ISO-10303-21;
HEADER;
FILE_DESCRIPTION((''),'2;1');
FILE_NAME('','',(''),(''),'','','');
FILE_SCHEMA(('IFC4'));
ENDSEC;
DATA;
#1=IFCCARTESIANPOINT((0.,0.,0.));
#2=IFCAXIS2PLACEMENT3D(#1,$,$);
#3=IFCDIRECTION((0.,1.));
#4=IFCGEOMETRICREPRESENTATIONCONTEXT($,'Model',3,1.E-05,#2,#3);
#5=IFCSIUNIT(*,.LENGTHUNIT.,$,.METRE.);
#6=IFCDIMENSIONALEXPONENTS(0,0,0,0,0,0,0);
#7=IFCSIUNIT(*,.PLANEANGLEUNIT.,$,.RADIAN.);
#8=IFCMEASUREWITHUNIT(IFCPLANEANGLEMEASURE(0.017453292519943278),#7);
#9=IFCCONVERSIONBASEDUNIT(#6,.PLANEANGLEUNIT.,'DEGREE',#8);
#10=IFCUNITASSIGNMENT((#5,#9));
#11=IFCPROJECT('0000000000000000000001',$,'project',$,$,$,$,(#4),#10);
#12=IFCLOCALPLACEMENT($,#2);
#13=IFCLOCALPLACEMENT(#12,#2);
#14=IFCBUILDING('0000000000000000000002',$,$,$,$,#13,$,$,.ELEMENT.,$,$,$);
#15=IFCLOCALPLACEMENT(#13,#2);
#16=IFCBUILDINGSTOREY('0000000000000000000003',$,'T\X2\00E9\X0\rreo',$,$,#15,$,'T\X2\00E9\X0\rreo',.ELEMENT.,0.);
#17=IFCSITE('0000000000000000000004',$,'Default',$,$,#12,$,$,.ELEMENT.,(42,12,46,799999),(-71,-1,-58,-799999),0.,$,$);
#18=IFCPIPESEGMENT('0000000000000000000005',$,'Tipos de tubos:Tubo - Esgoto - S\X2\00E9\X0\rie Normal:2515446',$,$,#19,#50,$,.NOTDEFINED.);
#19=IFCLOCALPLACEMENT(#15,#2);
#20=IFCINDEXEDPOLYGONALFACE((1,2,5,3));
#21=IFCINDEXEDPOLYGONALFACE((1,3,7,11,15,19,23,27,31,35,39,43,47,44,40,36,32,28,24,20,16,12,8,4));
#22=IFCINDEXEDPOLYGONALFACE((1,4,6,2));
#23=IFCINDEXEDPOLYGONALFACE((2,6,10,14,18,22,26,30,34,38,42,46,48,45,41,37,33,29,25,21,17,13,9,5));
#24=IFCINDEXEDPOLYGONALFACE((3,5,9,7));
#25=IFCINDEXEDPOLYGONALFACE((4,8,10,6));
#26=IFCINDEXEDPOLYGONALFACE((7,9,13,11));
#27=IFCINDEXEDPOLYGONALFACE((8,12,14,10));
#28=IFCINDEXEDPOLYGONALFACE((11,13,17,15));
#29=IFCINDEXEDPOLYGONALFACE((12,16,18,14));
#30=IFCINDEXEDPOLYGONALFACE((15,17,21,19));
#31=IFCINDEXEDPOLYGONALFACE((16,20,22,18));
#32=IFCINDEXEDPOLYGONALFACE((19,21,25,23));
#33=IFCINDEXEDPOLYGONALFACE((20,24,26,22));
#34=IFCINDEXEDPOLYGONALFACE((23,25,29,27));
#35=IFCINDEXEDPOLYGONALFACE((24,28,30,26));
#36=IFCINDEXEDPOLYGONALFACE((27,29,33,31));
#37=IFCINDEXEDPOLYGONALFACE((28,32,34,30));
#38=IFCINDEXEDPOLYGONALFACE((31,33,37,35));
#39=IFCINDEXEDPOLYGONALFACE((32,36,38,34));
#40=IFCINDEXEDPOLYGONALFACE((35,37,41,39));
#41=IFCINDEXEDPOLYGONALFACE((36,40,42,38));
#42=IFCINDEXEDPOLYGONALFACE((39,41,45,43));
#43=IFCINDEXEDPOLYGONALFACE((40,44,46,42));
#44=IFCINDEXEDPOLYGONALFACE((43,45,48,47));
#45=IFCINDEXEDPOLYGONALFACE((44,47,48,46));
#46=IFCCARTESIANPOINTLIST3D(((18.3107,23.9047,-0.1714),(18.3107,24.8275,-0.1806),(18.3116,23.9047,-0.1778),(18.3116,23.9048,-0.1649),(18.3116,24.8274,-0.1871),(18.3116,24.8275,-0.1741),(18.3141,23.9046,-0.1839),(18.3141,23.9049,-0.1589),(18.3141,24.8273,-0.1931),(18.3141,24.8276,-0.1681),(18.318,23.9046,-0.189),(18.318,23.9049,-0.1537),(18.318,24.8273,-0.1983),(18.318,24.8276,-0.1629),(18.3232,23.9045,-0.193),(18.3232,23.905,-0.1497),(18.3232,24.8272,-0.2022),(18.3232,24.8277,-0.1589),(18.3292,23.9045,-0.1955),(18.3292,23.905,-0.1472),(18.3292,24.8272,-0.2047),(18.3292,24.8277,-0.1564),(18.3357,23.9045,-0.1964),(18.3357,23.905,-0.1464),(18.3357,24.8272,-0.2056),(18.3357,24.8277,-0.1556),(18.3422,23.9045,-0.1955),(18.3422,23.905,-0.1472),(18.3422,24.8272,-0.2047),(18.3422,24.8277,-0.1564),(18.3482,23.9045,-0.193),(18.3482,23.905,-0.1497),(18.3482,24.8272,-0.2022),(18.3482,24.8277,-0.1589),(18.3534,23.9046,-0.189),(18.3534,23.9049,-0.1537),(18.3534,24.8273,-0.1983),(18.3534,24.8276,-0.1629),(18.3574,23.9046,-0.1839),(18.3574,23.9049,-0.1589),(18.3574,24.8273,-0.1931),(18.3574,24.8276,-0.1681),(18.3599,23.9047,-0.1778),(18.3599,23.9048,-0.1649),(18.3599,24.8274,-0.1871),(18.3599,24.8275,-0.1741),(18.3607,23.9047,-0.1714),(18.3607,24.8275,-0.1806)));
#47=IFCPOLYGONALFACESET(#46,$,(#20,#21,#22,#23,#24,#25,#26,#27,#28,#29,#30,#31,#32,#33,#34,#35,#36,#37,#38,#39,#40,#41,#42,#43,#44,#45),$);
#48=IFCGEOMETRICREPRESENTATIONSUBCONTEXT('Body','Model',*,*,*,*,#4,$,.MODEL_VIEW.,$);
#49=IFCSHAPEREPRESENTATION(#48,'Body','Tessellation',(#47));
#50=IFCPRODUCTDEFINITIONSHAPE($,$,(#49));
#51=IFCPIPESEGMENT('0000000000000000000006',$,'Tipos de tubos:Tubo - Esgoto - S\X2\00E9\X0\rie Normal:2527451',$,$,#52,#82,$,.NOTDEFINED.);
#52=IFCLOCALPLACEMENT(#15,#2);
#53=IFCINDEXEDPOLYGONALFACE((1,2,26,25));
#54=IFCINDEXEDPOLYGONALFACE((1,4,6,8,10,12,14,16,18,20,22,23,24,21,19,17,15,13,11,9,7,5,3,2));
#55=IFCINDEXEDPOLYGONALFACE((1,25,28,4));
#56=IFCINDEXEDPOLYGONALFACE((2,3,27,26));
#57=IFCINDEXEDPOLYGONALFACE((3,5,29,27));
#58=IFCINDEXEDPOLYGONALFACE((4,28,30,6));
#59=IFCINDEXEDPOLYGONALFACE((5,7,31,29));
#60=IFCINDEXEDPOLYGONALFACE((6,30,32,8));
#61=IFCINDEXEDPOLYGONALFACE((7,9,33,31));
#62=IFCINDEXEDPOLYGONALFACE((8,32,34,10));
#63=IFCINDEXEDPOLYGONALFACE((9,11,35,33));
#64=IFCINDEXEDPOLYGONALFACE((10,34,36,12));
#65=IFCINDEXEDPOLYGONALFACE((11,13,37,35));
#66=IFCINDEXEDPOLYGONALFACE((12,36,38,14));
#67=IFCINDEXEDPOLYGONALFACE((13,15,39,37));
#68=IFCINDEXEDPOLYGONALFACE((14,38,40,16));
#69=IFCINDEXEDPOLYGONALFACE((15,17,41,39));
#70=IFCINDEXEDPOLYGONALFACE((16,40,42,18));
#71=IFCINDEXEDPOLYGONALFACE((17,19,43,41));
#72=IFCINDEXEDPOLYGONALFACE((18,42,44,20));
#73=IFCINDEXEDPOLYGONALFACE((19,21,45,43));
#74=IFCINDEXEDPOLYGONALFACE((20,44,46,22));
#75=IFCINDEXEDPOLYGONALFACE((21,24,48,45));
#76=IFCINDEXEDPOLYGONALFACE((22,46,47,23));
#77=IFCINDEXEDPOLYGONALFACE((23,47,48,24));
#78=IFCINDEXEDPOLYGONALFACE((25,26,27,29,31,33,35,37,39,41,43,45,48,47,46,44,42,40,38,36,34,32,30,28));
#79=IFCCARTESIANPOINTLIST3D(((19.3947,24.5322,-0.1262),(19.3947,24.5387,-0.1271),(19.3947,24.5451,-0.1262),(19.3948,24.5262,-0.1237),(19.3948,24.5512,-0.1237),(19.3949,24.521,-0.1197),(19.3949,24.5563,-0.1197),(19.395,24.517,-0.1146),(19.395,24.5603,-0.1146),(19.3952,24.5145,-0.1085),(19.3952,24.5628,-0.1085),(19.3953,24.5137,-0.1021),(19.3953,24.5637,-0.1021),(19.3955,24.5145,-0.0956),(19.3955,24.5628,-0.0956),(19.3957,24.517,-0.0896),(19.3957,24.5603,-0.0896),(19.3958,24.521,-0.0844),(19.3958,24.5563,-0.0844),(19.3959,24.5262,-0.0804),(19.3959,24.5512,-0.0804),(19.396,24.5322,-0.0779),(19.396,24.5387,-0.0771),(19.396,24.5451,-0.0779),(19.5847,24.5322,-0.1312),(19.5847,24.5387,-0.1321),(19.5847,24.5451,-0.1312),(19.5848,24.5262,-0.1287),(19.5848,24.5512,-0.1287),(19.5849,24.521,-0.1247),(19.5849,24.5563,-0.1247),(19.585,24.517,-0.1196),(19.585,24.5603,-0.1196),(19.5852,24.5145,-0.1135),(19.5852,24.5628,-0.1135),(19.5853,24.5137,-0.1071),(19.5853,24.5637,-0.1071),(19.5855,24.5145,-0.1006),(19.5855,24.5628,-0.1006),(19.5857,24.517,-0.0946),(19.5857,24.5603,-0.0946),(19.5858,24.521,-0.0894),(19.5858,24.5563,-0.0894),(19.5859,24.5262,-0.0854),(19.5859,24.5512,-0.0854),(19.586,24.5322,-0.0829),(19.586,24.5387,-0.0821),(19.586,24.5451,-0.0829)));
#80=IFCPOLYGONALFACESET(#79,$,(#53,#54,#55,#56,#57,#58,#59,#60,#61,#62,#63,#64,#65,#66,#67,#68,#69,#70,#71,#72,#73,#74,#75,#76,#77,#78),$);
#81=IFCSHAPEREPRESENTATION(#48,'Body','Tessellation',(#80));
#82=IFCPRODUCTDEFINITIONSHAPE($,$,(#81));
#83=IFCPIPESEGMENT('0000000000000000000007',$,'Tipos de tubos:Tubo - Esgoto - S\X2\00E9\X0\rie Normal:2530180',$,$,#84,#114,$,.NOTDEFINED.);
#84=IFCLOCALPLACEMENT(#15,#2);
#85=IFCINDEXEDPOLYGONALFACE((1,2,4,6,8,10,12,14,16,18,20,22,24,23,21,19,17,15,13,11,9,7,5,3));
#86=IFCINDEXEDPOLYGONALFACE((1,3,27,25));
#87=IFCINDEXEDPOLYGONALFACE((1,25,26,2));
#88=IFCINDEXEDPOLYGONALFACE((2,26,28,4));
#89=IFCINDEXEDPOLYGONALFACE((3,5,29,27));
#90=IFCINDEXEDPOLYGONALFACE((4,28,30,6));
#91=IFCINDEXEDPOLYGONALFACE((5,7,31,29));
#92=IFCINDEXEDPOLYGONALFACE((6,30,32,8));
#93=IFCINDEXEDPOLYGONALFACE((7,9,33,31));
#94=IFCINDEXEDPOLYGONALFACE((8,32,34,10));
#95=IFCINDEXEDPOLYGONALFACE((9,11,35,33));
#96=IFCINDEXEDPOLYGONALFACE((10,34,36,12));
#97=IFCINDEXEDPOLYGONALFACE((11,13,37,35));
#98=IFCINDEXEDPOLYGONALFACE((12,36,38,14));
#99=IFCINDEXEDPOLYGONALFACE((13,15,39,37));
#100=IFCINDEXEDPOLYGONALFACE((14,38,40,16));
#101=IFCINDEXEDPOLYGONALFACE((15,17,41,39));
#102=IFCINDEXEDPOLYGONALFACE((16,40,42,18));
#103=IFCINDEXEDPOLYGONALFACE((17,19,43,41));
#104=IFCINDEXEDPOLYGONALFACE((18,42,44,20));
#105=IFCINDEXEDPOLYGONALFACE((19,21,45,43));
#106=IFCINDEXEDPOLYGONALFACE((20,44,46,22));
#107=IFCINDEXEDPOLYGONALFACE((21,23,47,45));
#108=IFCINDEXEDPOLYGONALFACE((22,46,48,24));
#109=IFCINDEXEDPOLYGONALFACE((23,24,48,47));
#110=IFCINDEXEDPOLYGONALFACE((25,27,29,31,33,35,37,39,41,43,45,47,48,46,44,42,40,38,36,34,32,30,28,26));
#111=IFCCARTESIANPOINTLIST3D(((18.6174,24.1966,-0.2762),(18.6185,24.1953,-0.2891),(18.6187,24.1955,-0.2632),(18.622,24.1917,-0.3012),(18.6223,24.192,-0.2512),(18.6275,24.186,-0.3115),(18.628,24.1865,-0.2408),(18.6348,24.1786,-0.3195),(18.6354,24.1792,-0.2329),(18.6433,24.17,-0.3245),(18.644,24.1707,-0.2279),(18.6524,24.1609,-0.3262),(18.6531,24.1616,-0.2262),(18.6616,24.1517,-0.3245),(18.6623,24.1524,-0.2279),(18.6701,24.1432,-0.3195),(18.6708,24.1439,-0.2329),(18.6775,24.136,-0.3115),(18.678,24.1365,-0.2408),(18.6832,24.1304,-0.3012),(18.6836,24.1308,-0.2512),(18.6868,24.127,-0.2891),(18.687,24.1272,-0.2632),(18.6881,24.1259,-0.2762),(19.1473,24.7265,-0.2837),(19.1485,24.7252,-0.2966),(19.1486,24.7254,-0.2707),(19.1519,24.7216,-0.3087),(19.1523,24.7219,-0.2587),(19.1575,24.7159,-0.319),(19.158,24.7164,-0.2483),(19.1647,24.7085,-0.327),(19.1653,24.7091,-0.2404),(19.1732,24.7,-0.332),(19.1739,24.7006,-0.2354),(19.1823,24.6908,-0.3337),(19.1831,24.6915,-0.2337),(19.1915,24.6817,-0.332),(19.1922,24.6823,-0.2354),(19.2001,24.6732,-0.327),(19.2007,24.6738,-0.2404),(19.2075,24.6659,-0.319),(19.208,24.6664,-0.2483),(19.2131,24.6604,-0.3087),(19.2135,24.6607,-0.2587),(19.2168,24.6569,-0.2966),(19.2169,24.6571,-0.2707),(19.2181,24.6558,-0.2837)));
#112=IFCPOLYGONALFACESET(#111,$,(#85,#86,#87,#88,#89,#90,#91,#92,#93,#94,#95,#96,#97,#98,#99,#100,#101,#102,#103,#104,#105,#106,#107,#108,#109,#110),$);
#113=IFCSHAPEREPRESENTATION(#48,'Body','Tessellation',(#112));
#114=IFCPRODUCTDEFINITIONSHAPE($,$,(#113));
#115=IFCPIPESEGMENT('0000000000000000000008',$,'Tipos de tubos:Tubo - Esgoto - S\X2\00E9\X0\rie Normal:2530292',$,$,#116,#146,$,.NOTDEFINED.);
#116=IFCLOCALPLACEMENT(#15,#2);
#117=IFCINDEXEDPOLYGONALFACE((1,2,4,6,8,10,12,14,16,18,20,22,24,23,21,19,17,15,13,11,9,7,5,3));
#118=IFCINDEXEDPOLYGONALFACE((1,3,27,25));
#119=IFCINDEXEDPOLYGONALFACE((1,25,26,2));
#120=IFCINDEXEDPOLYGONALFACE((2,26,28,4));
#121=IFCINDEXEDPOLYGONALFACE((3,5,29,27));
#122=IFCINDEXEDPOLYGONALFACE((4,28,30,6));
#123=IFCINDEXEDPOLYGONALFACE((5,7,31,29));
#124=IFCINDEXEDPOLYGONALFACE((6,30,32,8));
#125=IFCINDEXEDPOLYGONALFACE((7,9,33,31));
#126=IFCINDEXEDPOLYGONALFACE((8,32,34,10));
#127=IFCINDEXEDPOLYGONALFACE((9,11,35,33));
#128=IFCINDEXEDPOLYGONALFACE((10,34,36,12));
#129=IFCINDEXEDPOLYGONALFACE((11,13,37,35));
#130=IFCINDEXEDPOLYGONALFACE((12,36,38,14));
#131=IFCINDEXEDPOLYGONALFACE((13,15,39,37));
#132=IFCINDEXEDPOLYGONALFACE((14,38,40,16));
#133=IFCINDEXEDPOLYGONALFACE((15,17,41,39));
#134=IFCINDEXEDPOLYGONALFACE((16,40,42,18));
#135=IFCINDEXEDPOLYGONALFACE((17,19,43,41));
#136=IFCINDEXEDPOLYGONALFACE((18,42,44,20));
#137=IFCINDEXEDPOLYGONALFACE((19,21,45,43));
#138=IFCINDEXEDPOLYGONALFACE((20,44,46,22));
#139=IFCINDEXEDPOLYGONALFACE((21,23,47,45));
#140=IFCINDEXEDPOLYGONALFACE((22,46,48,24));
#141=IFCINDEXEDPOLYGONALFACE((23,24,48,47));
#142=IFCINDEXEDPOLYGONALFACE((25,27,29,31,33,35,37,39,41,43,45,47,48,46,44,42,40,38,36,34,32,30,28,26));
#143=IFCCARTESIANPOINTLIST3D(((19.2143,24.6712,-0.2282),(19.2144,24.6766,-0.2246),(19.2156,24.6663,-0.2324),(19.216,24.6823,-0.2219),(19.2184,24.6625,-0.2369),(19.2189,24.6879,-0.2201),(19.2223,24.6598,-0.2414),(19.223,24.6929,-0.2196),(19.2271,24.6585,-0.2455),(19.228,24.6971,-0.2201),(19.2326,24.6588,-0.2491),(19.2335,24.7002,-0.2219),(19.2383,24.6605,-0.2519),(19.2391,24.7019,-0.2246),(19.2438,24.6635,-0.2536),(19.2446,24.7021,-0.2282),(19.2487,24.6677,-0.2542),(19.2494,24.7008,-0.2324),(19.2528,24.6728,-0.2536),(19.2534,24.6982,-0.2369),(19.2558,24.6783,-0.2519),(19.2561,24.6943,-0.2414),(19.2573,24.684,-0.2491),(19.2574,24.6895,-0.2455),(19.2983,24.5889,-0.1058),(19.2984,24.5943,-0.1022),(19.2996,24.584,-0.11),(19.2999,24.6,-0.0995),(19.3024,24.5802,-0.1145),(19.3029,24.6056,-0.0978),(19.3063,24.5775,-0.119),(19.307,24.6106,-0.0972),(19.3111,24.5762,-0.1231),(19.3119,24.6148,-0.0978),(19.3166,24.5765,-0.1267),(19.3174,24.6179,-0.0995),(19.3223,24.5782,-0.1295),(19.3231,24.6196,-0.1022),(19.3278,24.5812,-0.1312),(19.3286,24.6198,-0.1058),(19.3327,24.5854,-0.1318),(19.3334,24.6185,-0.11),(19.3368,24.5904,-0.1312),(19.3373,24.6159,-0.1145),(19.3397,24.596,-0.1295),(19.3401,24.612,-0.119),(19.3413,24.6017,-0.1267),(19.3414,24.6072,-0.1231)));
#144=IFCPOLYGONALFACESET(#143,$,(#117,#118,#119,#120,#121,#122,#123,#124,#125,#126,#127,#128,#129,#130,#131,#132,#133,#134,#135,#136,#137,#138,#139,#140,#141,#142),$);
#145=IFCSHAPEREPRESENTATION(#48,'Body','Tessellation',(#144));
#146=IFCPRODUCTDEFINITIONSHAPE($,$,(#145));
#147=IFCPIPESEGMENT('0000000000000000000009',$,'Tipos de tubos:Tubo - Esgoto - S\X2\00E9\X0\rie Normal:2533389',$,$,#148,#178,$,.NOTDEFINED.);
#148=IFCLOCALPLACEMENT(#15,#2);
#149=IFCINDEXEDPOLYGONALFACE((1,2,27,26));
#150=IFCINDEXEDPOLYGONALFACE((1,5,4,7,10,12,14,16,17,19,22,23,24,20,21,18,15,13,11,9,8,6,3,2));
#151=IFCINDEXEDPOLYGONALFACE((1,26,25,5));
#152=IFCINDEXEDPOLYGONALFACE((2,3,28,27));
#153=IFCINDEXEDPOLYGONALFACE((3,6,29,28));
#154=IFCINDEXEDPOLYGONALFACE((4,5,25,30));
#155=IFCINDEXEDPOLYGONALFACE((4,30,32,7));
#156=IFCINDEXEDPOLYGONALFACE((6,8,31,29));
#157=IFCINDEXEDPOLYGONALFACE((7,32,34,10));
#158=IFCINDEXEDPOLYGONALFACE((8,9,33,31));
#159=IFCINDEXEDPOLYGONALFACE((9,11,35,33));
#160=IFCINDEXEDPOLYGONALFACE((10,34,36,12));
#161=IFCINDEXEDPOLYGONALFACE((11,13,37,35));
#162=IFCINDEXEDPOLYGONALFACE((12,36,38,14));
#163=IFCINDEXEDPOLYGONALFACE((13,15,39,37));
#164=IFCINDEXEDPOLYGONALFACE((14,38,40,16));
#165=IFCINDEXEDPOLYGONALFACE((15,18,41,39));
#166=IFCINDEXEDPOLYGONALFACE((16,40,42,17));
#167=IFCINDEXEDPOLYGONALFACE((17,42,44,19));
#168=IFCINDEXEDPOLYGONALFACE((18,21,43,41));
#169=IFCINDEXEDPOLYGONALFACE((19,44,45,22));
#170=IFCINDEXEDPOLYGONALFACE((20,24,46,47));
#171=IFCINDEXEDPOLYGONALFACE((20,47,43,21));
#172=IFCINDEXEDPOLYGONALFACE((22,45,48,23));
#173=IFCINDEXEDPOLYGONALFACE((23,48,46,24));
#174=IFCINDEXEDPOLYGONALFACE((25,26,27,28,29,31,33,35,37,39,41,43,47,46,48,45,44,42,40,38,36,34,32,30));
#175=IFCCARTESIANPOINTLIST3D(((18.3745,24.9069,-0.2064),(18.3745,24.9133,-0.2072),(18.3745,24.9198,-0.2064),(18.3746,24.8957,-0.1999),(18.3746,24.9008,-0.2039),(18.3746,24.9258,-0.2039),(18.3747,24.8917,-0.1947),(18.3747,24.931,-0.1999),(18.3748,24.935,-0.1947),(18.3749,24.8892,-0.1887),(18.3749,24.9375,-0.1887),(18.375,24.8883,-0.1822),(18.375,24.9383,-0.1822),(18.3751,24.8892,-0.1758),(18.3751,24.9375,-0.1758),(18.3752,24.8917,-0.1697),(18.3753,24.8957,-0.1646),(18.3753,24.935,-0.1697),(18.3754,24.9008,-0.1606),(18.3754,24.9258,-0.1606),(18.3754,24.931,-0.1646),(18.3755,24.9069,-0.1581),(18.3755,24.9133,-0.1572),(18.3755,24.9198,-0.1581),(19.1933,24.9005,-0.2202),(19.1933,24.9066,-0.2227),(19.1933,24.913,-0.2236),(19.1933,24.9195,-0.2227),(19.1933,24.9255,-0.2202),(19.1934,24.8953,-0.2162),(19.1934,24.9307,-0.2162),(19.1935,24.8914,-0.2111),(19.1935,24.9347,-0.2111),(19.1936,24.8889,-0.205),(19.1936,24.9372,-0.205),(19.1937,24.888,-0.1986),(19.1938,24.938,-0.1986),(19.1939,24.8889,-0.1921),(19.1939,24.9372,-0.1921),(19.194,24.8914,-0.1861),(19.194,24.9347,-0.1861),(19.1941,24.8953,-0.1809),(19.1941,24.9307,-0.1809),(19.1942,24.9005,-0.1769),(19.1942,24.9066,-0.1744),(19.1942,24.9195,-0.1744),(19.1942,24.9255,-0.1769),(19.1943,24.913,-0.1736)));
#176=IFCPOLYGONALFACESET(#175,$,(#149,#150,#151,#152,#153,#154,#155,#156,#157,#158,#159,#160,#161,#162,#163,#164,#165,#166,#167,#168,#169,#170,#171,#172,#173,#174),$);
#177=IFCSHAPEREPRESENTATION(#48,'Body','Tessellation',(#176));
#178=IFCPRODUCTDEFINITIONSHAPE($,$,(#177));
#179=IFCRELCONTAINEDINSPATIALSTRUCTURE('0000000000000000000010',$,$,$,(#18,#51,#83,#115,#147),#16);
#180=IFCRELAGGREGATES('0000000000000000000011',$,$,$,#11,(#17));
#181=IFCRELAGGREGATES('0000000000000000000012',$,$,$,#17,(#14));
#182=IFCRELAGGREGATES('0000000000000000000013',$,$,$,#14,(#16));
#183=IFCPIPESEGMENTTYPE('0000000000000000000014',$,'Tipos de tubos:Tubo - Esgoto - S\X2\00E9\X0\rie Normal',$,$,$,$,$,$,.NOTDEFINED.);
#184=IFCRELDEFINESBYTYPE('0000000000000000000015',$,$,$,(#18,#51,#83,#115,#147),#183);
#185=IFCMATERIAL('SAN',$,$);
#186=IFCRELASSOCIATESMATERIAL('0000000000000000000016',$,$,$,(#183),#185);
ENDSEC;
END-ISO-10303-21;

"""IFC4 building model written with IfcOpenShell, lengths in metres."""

from ifc_helpers import new_model, entity, si_unit, converted_unit, direction, frame, origin, place, context, subcontext, project, spatial, arc, indexed_curve, outline, extrude, material, type_object, element, save


model = new_model("IFC4")

# Units and contexts
model_context = context("Model", 3, precision=1e-05, world=origin(), true_north=direction((0.0, 1.0)))
body_context = subcontext(model_context, "Body", "Model", "MODEL_VIEW")
ifc_project = project(units=[si_unit("LENGTHUNIT", "METRE"), converted_unit("PLANEANGLEUNIT", "DEGREE", entity("IfcPlaneAngleMeasure", 0.017453292519943278), si_unit("PLANEANGLEUNIT", "RADIAN"), dimensions=[0, 0, 0, 0, 0, 0, 0])], contexts=[model_context])

# Site, building, storey
site_placement = place(None, origin())
site = spatial("IfcSite", under=ifc_project, at=site_placement, Name="Default", CompositionType="ELEMENT", RefLatitude=(42, 12, 46, 799999), RefLongitude=(-71, -1, -58, -799999), RefElevation=0.0)
building_placement = place(site_placement, origin())
building = spatial("IfcBuilding", under=site, at=building_placement, CompositionType="ELEMENT")
storey_placement = place(building_placement, origin())
storey = spatial("IfcBuildingStorey", under=building, at=storey_placement, Name="Térreo", LongName="Térreo", CompositionType="ELEMENT", Elevation=0.0)

# Pipe segments
ifc_material_1 = material(Name="SAN")
pipe_segment_type_1 = type_object("IfcPipeSegmentType", Name="Tipos de tubos:Tubo - Esgoto - Série Normal", PredefinedType="NOTDEFINED", material=ifc_material_1)
pipe_segment_1_placement = place(storey_placement, origin())
element("IfcPipeSegment", 1, at=pipe_segment_1_placement, inside=storey, type_object=pipe_segment_type_1, Name="Tipos de tubos:Tubo - Esgoto - Série Normal:2515446", PredefinedType="NOTDEFINED", context=body_context, shape_type="SweptSolid", body=[
    extrude(outline(indexed_curve([(0.025, 0.0), (0.0177, 0.0177), (0.0, 0.025), (-0.0177, 0.0177), (-0.025, 0.0), (-0.0177, -0.0177), (0.0, -0.025), (0.0177, -0.0177)], segments=[arc(1, 2, 3), arc(3, 4, 5), arc(5, 6, 7), arc(7, 8, 1)], self_intersect=False)), frame((18.3357, 24.8275, -0.1806), z_axis=(0.0, -0.99995, 0.01), x_axis=(-1.0, 0.0, 0.0)), (0.0, 0.0, 1.0), 0.9228),
])
pipe_segment_2_placement = place(storey_placement, origin())
element("IfcPipeSegment", 2, at=pipe_segment_2_placement, inside=storey, type_object=pipe_segment_type_1, Name="Tipos de tubos:Tubo - Esgoto - Série Normal:2527451", PredefinedType="NOTDEFINED", context=body_context, shape_type="SweptSolid", body=[
    extrude(outline(indexed_curve([(0.025, 0.0), (0.0177, 0.0177), (0.0, 0.025), (-0.0177, 0.0177), (-0.025, 0.0), (-0.0177, -0.0177), (0.0, -0.025), (0.0177, -0.0177)], segments=[arc(1, 2, 3), arc(3, 4, 5), arc(5, 6, 7), arc(7, 8, 1)], self_intersect=False)), frame((19.5853, 24.5387, -0.1071), z_axis=(-0.999654, 0.0, 0.026305), x_axis=(0.0, 1.0, 0.0)), (0.0, 0.0, 1.0), 0.1901),
])
pipe_segment_3_placement = place(storey_placement, origin())
element("IfcPipeSegment", 3, at=pipe_segment_3_placement, inside=storey, type_object=pipe_segment_type_1, Name="Tipos de tubos:Tubo - Esgoto - Série Normal:2530180", PredefinedType="NOTDEFINED", context=body_context, shape_type="SweptSolid", body=[
    extrude(outline(indexed_curve([(0.05, 0.0), (0.0354, 0.0354), (0.0, 0.05), (-0.0354, 0.0354), (-0.05, 0.0), (-0.0354, -0.0354), (0.0, -0.05), (0.0354, -0.0354)], segments=[arc(1, 2, 3), arc(3, 4, 5), arc(5, 6, 7), arc(7, 8, 1)], self_intersect=False)), frame((19.1827, 24.6911, -0.2837), z_axis=(-0.707078, -0.707065, 0.00999), x_axis=(0.7071, -0.707114, 0.0)), (0.0, 0.0, 1.0), 0.7495),
])
pipe_segment_4_placement = place(storey_placement, origin())
element("IfcPipeSegment", 4, at=pipe_segment_4_placement, inside=storey, type_object=pipe_segment_type_1, Name="Tipos de tubos:Tubo - Esgoto - Série Normal:2530292", PredefinedType="NOTDEFINED", context=body_context, shape_type="SweptSolid", body=[
    extrude(outline(indexed_curve([(0.025, 0.0), (0.0177, 0.0177), (0.0, 0.025), (-0.0177, 0.0177), (-0.025, 0.0), (-0.0177, -0.0177), (0.0, -0.025), (0.0177, -0.0177)], segments=[arc(1, 2, 3), arc(3, 4, 5), arc(5, 6, 7), arc(7, 8, 1)], self_intersect=False)), frame((19.2359, 24.6803, -0.2369), z_axis=(0.494857, -0.484948, 0.72107), x_axis=(-0.699919, -0.714222, 0.0)), (0.0, 0.0, 1.0), 0.1697),
])
pipe_segment_5_placement = place(storey_placement, origin())
element("IfcPipeSegment", 5, at=pipe_segment_5_placement, inside=storey, type_object=pipe_segment_type_1, Name="Tipos de tubos:Tubo - Esgoto - Série Normal:2533389", PredefinedType="NOTDEFINED", context=body_context, shape_type="SweptSolid", body=[
    extrude(outline(indexed_curve([(0.025, 0.0), (0.0177, 0.0177), (0.0, 0.025), (-0.0177, 0.0177), (-0.025, 0.0), (-0.0177, -0.0177), (0.0, -0.025), (0.0177, -0.0177)], segments=[arc(1, 2, 3), arc(3, 4, 5), arc(5, 6, 7), arc(7, 8, 1)], self_intersect=False)), frame((18.375, 24.9133, -0.1822), z_axis=(0.999801, -0.000381, -0.019945), x_axis=(0.000381, 1.0, 0.0)), (0.0, 0.0, 1.0), 0.8189),
])

save(model, "model.ifc")
